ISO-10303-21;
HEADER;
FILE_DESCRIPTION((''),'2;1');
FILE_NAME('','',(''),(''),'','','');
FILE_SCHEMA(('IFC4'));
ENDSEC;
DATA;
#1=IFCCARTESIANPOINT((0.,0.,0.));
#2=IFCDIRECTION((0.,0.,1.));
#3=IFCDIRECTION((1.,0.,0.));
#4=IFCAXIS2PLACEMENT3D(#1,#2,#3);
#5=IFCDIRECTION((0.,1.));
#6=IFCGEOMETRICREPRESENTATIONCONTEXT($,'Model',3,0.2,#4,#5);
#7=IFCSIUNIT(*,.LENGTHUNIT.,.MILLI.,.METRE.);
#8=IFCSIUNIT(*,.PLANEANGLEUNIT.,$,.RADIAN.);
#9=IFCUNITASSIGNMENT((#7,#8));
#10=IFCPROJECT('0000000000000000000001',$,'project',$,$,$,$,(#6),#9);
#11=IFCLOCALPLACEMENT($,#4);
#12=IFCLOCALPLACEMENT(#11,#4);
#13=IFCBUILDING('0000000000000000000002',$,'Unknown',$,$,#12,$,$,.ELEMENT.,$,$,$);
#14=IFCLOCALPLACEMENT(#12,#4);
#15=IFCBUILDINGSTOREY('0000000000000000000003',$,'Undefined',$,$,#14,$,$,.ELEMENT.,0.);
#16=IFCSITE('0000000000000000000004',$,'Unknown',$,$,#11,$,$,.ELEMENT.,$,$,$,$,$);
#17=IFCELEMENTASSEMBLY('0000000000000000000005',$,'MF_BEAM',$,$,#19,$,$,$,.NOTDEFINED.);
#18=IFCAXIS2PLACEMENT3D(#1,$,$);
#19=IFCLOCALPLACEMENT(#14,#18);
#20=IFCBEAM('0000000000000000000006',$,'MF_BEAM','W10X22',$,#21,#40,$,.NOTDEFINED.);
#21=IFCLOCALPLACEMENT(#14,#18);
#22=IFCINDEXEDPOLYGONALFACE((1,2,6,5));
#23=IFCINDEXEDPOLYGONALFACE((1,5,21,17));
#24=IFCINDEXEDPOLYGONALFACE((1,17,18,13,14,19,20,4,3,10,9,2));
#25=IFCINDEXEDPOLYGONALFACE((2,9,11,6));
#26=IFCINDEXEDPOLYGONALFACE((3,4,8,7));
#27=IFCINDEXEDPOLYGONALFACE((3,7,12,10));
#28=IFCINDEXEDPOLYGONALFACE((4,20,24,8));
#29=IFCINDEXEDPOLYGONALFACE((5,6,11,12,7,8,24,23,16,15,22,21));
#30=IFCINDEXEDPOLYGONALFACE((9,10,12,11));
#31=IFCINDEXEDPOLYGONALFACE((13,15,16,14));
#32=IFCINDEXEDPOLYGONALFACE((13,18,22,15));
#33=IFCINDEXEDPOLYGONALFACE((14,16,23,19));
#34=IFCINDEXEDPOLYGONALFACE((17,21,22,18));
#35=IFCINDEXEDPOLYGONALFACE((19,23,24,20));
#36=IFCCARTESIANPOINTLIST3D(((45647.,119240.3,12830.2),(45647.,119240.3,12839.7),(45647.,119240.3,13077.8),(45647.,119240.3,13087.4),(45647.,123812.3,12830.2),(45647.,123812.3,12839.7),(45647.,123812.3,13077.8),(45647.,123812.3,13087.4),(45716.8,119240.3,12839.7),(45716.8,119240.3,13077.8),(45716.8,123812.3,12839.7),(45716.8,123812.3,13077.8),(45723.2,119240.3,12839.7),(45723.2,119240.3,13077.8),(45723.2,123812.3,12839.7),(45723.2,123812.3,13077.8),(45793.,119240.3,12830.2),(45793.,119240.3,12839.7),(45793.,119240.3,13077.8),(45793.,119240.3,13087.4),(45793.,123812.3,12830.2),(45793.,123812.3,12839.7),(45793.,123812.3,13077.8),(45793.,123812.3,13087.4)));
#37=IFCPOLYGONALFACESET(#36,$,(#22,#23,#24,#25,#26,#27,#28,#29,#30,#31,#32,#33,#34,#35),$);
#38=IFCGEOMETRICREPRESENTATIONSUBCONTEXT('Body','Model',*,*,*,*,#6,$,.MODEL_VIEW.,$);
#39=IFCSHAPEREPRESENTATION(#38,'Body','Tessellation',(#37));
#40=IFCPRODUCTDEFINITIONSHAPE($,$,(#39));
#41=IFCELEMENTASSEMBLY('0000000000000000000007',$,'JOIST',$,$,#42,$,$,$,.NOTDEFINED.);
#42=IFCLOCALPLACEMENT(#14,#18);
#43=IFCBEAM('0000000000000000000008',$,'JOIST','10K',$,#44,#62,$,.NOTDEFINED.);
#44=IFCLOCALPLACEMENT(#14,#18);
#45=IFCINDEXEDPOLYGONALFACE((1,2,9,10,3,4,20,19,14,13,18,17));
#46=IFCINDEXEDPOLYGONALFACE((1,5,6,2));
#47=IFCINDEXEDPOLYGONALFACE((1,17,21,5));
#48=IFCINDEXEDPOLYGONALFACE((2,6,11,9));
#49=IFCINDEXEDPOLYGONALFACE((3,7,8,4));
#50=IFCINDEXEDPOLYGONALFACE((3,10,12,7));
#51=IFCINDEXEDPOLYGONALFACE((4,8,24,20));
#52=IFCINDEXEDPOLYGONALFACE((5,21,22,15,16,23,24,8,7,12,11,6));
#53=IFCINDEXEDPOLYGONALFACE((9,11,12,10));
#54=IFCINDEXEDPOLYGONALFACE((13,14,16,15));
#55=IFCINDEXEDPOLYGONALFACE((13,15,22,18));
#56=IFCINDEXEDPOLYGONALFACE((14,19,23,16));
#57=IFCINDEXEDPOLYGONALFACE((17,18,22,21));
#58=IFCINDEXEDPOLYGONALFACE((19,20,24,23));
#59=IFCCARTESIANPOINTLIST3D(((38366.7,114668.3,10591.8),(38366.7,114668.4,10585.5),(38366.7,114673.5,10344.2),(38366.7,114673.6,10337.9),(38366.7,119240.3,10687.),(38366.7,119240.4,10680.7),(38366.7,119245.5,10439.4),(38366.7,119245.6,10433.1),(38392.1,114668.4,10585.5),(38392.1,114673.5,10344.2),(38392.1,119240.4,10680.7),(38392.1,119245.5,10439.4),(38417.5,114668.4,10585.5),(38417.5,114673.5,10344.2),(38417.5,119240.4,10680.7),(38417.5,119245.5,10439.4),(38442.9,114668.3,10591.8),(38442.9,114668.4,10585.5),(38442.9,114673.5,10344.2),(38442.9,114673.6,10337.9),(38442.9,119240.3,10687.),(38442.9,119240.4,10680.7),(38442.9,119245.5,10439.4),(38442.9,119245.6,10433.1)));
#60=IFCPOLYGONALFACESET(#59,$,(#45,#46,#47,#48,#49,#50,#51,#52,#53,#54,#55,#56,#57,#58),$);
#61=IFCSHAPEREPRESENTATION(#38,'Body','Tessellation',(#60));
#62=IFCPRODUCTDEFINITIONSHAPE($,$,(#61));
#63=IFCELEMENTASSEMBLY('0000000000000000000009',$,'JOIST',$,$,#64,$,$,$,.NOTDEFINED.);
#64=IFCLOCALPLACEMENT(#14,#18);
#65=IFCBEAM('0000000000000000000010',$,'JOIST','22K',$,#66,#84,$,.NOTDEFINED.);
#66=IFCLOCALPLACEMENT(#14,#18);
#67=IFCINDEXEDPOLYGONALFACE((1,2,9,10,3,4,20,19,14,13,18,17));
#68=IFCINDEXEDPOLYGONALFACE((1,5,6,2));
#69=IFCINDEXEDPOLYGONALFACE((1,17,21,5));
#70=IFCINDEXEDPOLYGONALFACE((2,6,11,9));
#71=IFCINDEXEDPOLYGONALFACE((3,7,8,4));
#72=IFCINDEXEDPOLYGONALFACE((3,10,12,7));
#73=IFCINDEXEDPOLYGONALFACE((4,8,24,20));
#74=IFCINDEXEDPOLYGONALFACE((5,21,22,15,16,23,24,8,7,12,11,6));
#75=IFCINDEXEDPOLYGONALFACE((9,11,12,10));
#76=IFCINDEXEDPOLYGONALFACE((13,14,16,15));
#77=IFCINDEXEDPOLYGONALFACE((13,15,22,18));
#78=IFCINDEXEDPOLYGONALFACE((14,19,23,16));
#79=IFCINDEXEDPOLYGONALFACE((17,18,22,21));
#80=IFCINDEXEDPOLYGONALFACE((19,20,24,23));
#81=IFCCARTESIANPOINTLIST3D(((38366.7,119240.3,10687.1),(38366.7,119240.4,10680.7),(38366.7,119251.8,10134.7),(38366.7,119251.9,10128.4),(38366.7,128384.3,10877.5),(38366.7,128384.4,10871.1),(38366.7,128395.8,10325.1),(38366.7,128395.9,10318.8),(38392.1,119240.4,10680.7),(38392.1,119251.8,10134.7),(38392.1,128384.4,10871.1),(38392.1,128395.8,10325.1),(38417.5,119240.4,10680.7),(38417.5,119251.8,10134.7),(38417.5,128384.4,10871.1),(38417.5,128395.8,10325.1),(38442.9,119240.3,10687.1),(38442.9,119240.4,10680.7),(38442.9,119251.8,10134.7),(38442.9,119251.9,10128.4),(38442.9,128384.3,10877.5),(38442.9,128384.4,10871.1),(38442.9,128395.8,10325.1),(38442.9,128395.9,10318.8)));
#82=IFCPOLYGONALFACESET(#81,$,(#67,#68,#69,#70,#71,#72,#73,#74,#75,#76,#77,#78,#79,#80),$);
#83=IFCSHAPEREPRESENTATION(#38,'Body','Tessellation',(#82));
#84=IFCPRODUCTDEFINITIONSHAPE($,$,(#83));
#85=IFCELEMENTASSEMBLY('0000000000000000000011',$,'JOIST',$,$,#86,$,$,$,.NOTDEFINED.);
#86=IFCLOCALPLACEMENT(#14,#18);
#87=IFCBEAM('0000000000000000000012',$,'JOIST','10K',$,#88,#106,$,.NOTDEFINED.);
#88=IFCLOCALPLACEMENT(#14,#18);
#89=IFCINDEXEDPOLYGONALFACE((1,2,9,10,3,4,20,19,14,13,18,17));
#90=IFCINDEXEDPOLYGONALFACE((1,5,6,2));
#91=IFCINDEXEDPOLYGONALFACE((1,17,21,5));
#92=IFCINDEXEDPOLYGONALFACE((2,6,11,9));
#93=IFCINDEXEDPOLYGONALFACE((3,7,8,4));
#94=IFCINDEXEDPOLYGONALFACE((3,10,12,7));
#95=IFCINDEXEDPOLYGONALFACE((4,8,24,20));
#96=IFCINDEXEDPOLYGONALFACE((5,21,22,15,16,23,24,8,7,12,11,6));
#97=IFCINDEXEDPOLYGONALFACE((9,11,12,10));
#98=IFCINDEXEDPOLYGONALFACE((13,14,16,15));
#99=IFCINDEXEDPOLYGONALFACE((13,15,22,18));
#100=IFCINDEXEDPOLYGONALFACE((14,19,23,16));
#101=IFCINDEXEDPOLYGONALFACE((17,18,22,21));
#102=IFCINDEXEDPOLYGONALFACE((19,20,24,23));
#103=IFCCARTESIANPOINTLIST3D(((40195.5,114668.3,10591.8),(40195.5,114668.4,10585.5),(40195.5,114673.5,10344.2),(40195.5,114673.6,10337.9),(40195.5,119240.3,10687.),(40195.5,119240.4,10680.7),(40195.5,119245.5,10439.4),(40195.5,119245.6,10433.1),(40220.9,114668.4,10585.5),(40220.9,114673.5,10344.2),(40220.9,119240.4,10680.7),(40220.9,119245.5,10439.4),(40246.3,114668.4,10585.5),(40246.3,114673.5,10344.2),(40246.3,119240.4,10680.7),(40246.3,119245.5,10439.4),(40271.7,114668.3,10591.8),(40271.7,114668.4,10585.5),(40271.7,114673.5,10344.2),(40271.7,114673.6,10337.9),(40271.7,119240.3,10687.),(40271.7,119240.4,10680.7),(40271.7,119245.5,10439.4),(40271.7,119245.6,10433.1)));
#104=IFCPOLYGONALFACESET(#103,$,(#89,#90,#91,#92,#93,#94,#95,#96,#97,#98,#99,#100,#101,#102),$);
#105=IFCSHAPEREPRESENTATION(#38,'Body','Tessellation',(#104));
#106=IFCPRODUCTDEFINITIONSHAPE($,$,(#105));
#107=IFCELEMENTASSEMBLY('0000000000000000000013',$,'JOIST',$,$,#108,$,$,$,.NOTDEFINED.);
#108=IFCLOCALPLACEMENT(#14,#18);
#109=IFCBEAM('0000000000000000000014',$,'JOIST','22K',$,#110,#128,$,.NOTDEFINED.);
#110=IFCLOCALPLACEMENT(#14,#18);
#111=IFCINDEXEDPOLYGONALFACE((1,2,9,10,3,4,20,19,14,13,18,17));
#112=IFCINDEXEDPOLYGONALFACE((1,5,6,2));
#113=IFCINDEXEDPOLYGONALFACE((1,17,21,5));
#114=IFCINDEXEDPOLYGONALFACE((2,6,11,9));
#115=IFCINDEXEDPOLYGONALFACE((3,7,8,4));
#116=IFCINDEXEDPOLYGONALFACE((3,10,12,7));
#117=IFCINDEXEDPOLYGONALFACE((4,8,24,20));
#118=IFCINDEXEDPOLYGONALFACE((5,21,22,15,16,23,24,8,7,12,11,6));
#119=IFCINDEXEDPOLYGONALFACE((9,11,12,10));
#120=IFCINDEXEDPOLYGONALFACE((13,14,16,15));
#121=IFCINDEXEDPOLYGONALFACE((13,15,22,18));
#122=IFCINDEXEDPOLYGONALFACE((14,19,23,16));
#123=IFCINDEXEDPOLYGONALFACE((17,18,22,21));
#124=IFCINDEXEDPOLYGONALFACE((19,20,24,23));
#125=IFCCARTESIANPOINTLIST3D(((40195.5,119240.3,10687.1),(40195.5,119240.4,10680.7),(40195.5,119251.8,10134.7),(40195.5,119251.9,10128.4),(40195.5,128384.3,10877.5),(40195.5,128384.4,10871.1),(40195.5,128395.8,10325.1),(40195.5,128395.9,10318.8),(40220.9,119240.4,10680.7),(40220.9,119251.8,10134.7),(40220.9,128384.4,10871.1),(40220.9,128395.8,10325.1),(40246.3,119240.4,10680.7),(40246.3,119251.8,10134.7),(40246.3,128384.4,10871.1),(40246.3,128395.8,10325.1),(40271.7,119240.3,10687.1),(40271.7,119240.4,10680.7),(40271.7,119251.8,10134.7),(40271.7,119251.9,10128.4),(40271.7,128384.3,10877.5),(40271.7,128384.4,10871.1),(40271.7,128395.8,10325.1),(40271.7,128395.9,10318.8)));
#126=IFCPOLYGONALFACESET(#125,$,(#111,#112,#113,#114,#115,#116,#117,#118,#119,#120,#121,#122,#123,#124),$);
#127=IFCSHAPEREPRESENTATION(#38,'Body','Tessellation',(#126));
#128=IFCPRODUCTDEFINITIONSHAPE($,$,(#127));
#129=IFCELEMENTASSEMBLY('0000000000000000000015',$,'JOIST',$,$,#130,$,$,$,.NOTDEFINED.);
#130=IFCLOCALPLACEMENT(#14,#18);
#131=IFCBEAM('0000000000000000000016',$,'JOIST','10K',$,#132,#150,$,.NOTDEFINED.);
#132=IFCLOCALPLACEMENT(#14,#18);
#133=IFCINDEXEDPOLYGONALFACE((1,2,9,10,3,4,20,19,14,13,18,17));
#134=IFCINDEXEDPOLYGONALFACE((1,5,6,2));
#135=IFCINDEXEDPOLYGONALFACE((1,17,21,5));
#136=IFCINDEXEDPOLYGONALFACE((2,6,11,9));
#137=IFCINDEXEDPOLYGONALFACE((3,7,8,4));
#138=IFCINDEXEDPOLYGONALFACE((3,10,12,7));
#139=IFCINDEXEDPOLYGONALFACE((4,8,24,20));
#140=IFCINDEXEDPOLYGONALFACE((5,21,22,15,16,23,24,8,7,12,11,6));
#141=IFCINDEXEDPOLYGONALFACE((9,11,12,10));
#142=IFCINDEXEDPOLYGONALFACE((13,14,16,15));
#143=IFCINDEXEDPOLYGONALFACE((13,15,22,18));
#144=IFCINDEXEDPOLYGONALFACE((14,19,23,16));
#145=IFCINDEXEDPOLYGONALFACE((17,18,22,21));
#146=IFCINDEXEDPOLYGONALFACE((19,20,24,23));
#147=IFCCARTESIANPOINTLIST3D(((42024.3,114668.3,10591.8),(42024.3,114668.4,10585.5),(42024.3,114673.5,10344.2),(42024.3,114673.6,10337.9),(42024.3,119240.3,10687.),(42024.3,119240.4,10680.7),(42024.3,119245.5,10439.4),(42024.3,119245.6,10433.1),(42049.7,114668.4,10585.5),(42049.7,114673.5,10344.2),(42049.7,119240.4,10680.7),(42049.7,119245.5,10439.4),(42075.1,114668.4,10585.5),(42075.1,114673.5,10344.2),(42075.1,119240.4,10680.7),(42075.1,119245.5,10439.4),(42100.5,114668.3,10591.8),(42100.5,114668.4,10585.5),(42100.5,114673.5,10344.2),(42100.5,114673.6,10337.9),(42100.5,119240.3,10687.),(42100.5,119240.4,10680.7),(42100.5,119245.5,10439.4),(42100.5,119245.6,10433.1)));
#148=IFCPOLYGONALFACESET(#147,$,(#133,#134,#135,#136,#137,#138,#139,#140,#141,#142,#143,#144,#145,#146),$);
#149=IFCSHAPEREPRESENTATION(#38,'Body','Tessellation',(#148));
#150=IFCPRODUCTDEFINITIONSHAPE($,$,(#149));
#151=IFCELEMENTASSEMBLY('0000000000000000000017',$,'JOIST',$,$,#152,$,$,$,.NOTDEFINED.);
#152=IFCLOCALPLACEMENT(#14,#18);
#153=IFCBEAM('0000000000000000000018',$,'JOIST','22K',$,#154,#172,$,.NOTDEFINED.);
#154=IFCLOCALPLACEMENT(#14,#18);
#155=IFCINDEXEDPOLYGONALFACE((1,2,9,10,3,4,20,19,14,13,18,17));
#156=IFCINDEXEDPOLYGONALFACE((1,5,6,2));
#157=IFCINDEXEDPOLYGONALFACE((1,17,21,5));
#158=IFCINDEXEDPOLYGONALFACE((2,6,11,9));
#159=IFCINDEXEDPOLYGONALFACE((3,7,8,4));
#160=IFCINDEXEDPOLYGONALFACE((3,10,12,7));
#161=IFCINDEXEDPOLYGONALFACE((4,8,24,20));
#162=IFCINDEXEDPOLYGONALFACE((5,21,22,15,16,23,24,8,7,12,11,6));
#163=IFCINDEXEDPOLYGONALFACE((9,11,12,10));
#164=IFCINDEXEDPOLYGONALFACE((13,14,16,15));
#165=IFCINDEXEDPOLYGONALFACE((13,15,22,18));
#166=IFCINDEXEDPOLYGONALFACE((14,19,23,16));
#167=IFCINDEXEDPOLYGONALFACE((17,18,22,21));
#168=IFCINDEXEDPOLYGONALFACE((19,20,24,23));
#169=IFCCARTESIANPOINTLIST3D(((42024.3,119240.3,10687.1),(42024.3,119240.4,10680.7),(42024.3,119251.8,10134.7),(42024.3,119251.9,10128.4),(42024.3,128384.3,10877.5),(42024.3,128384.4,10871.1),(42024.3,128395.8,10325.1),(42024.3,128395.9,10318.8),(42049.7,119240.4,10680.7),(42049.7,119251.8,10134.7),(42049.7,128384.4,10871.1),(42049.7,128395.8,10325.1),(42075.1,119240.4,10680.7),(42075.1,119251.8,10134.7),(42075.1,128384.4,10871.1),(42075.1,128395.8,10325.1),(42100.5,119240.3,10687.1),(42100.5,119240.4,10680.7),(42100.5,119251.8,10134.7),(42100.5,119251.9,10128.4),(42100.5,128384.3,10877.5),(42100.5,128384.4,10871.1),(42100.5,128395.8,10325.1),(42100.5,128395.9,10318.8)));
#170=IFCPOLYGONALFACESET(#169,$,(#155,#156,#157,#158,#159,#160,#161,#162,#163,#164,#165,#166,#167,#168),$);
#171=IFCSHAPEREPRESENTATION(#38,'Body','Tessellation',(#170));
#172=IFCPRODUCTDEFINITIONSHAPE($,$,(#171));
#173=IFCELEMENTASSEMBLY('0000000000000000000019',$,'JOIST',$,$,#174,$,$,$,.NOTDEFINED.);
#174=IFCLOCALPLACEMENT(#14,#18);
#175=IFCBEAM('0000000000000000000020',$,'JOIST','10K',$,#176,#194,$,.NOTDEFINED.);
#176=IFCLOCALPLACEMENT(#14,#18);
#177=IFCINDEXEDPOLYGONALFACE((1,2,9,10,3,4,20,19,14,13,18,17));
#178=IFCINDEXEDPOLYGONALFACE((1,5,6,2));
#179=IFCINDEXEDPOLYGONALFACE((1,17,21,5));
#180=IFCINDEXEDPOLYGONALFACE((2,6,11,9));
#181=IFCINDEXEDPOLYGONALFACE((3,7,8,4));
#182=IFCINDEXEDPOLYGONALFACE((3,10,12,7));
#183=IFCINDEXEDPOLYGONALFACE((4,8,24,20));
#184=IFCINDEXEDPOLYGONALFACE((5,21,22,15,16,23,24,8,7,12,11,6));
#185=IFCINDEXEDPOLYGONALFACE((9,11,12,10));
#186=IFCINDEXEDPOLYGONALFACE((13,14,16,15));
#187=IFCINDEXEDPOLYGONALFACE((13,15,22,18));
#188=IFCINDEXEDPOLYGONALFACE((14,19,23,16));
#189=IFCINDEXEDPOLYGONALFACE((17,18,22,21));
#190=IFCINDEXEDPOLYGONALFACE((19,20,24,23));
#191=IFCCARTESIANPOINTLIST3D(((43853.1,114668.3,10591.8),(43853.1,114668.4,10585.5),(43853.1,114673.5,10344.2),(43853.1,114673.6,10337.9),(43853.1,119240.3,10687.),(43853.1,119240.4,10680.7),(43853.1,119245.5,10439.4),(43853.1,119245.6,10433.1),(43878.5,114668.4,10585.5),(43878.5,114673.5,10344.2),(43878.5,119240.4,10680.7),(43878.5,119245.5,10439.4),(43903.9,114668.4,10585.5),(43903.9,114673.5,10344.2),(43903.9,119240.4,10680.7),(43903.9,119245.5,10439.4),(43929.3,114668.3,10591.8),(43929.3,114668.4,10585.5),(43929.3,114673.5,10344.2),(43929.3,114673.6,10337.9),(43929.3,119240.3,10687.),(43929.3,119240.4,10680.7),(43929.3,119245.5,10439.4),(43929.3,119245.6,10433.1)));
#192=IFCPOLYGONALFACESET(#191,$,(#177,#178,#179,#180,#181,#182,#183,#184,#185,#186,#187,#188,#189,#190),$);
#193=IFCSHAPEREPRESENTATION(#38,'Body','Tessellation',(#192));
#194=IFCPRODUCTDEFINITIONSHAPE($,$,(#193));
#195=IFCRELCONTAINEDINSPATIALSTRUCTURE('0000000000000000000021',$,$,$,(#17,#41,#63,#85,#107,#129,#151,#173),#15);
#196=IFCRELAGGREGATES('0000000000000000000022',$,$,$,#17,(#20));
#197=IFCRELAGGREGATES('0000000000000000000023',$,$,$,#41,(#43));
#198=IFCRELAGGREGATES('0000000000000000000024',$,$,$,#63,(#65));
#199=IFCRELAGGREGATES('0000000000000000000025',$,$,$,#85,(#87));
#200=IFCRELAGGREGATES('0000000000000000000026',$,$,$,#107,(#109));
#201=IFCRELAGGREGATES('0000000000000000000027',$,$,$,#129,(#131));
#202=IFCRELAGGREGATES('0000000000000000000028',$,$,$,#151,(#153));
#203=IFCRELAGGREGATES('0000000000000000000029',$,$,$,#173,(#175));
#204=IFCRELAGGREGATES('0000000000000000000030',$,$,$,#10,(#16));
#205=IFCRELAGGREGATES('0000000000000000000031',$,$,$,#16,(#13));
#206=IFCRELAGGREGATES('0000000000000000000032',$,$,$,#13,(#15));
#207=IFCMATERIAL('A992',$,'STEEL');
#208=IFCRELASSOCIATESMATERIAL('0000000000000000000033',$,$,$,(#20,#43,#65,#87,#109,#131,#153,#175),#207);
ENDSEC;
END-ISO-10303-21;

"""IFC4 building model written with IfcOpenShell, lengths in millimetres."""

from ifc_helpers import new_model, si_unit, direction, frame, origin_with_axes, place, context, subcontext, project, spatial, line, indexed_curve, outline, extrude, material, element, aggregate, save


model = new_model("IFC4")

# Units and contexts
model_context = context("Model", 3, precision=0.2, world=origin_with_axes(), true_north=direction((0.0, 1.0)))
body_context = subcontext(model_context, "Body", "Model", "MODEL_VIEW")
ifc_project = project(units=[si_unit("LENGTHUNIT", "METRE", prefix="MILLI"), si_unit("PLANEANGLEUNIT", "RADIAN")], contexts=[model_context])

# Site, building, storey
site_placement = place(None, origin_with_axes())
site = spatial("IfcSite", under=ifc_project, at=site_placement, Name="Unknown", CompositionType="ELEMENT")
building_placement = place(site_placement, origin_with_axes())
building = spatial("IfcBuilding", under=site, at=building_placement, Name="Unknown", CompositionType="ELEMENT")
storey_placement = place(building_placement, origin_with_axes())
storey = spatial("IfcBuildingStorey", under=building, at=storey_placement, Name="Undefined", CompositionType="ELEMENT", Elevation=0.0)

# Element assemblies, beams
assembly_1_placement = place(storey_placement, frame((45720.0, 119240.3, 12958.8), z_axis=(1.0, 0.0, 0.0), x_axis=(0.0, 1.0, 0.0)))
assembly_1 = element("IfcElementAssembly", 1, at=assembly_1_placement, inside=storey, Name="MF_BEAM", PredefinedType="NOTDEFINED")
ifc_material_1 = material(Name="A992", Category="STEEL")
beam_1_placement = place(assembly_1_placement, origin_with_axes())
beam_1 = element("IfcBeam", 2, at=beam_1_placement, material=ifc_material_1, Name="MF_BEAM", Description="W10X22", PredefinedType="NOTDEFINED", context=body_context, shape_type="SolidModel", body=[
    extrude(outline(indexed_curve([(-73.0, -128.6), (73.0, -128.6), (73.0, -119.1), (3.2, -119.1), (3.2, 119.1), (73.0, 119.1), (73.0, 128.6), (-73.0, 128.6), (-73.0, 119.1), (-3.2, 119.1), (-3.2, -119.1), (-73.0, -119.1)], segments=[line(1, 2, 3, 4, 5, 6, 7, 8, 9, 10, 11, 12, 1)])), frame((0.0, 0.0, 0.0), z_axis=(-1.0, 0.0, 0.0), x_axis=(0.0, 0.0, 1.0)), (0.0, 0.0, -1.0), 4572.0),
])
aggregate(assembly_1, [beam_1])
assembly_2_placement = place(storey_placement, frame((38404.8, 114670.9, 10464.8), z_axis=(1.0, 0.0, 0.0), x_axis=(0.0, 0.999783, 0.020819)))
assembly_2 = element("IfcElementAssembly", 3, at=assembly_2_placement, inside=storey, Name="JOIST", PredefinedType="NOTDEFINED")
beam_2_placement = place(assembly_2_placement, origin_with_axes())
beam_2 = element("IfcBeam", 4, at=beam_2_placement, material=ifc_material_1, Name="JOIST", Description="10K", PredefinedType="NOTDEFINED", context=body_context, shape_type="SolidModel", body=[
    extrude(outline(indexed_curve([(-38.1, -127.0), (38.1, -127.0), (38.1, -120.7), (12.7, -120.7), (12.7, 120.7), (38.1, 120.7), (38.1, 127.0), (-38.1, 127.0), (-38.1, 120.7), (-12.7, 120.7), (-12.7, -120.7), (-38.1, -120.7)], segments=[line(1, 2, 3, 4, 5, 6, 7, 8, 9, 10, 11, 12, 1)])), frame((0.0, 0.0, 0.0), z_axis=(-1.0, 0.0, 0.0), x_axis=(0.0, 0.0, 1.0)), (0.0, 0.0, -1.0), 4573.0),
])
aggregate(assembly_2, [beam_2])
assembly_3_placement = place(storey_placement, frame((38404.8, 119246.1, 10407.7), z_axis=(1.0, 0.0, 0.0), x_axis=(0.0, 0.999783, 0.020819)))
assembly_3 = element("IfcElementAssembly", 5, at=assembly_3_placement, inside=storey, Name="JOIST", PredefinedType="NOTDEFINED")
beam_3_placement = place(assembly_3_placement, origin_with_axes())
beam_3 = element("IfcBeam", 6, at=beam_3_placement, material=ifc_material_1, Name="JOIST", Description="22K", PredefinedType="NOTDEFINED", context=body_context, shape_type="SolidModel", body=[
    extrude(outline(indexed_curve([(-38.1, -279.4), (38.1, -279.4), (38.1, -273.0), (12.7, -273.0), (12.7, 273.0), (38.1, 273.0), (38.1, 279.4), (-38.1, 279.4), (-38.1, 273.0), (-12.7, 273.0), (-12.7, -273.0), (-38.1, -273.0)], segments=[line(1, 2, 3, 4, 5, 6, 7, 8, 9, 10, 11, 12, 1)])), frame((0.0, 0.0, 0.0), z_axis=(-1.0, 0.0, 0.0), x_axis=(0.0, 0.0, 1.0)), (0.0, 0.0, -1.0), 9146.0),
])
aggregate(assembly_3, [beam_3])
assembly_4_placement = place(storey_placement, frame((40233.6, 114670.9, 10464.8), z_axis=(1.0, 0.0, 0.0), x_axis=(0.0, 0.999783, 0.020819)))
assembly_4 = element("IfcElementAssembly", 7, at=assembly_4_placement, inside=storey, Name="JOIST", PredefinedType="NOTDEFINED")
beam_4_placement = place(assembly_4_placement, origin_with_axes())
beam_4 = element("IfcBeam", 8, at=beam_4_placement, material=ifc_material_1, Name="JOIST", Description="10K", PredefinedType="NOTDEFINED", context=body_context, shape_type="SolidModel", body=[
    extrude(outline(indexed_curve([(-38.1, -127.0), (38.1, -127.0), (38.1, -120.7), (12.7, -120.7), (12.7, 120.7), (38.1, 120.7), (38.1, 127.0), (-38.1, 127.0), (-38.1, 120.7), (-12.7, 120.7), (-12.7, -120.7), (-38.1, -120.7)], segments=[line(1, 2, 3, 4, 5, 6, 7, 8, 9, 10, 11, 12, 1)])), frame((0.0, 0.0, 0.0), z_axis=(-1.0, 0.0, 0.0), x_axis=(0.0, 0.0, 1.0)), (0.0, 0.0, -1.0), 4573.0),
])
aggregate(assembly_4, [beam_4])
assembly_5_placement = place(storey_placement, frame((40233.6, 119246.1, 10407.7), z_axis=(1.0, 0.0, 0.0), x_axis=(0.0, 0.999783, 0.020819)))
assembly_5 = element("IfcElementAssembly", 9, at=assembly_5_placement, inside=storey, Name="JOIST", PredefinedType="NOTDEFINED")
beam_5_placement = place(assembly_5_placement, origin_with_axes())
beam_5 = element("IfcBeam", 10, at=beam_5_placement, material=ifc_material_1, Name="JOIST", Description="22K", PredefinedType="NOTDEFINED", context=body_context, shape_type="SolidModel", body=[
    extrude(outline(indexed_curve([(-38.1, -279.4), (38.1, -279.4), (38.1, -273.0), (12.7, -273.0), (12.7, 273.0), (38.1, 273.0), (38.1, 279.4), (-38.1, 279.4), (-38.1, 273.0), (-12.7, 273.0), (-12.7, -273.0), (-38.1, -273.0)], segments=[line(1, 2, 3, 4, 5, 6, 7, 8, 9, 10, 11, 12, 1)])), frame((0.0, 0.0, 0.0), z_axis=(-1.0, 0.0, 0.0), x_axis=(0.0, 0.0, 1.0)), (0.0, 0.0, -1.0), 9146.0),
])
aggregate(assembly_5, [beam_5])
assembly_6_placement = place(storey_placement, frame((42062.4, 114670.9, 10464.8), z_axis=(1.0, 0.0, 0.0), x_axis=(0.0, 0.999783, 0.020819)))
assembly_6 = element("IfcElementAssembly", 11, at=assembly_6_placement, inside=storey, Name="JOIST", PredefinedType="NOTDEFINED")
beam_6_placement = place(assembly_6_placement, origin_with_axes())
beam_6 = element("IfcBeam", 12, at=beam_6_placement, material=ifc_material_1, Name="JOIST", Description="10K", PredefinedType="NOTDEFINED", context=body_context, shape_type="SolidModel", body=[
    extrude(outline(indexed_curve([(-38.1, -127.0), (38.1, -127.0), (38.1, -120.7), (12.7, -120.7), (12.7, 120.7), (38.1, 120.7), (38.1, 127.0), (-38.1, 127.0), (-38.1, 120.7), (-12.7, 120.7), (-12.7, -120.7), (-38.1, -120.7)], segments=[line(1, 2, 3, 4, 5, 6, 7, 8, 9, 10, 11, 12, 1)])), frame((0.0, 0.0, 0.0), z_axis=(-1.0, 0.0, 0.0), x_axis=(0.0, 0.0, 1.0)), (0.0, 0.0, -1.0), 4573.0),
])
aggregate(assembly_6, [beam_6])
assembly_7_placement = place(storey_placement, frame((42062.4, 119246.1, 10407.7), z_axis=(1.0, 0.0, 0.0), x_axis=(0.0, 0.999783, 0.020819)))
assembly_7 = element("IfcElementAssembly", 13, at=assembly_7_placement, inside=storey, Name="JOIST", PredefinedType="NOTDEFINED")
beam_7_placement = place(assembly_7_placement, origin_with_axes())
beam_7 = element("IfcBeam", 14, at=beam_7_placement, material=ifc_material_1, Name="JOIST", Description="22K", PredefinedType="NOTDEFINED", context=body_context, shape_type="SolidModel", body=[
    extrude(outline(indexed_curve([(-38.1, -279.4), (38.1, -279.4), (38.1, -273.0), (12.7, -273.0), (12.7, 273.0), (38.1, 273.0), (38.1, 279.4), (-38.1, 279.4), (-38.1, 273.0), (-12.7, 273.0), (-12.7, -273.0), (-38.1, -273.0)], segments=[line(1, 2, 3, 4, 5, 6, 7, 8, 9, 10, 11, 12, 1)])), frame((0.0, 0.0, 0.0), z_axis=(-1.0, 0.0, 0.0), x_axis=(0.0, 0.0, 1.0)), (0.0, 0.0, -1.0), 9146.0),
])
aggregate(assembly_7, [beam_7])
assembly_8_placement = place(storey_placement, frame((43891.2, 114670.9, 10464.8), z_axis=(1.0, 0.0, 0.0), x_axis=(0.0, 0.999783, 0.020819)))
assembly_8 = element("IfcElementAssembly", 15, at=assembly_8_placement, inside=storey, Name="JOIST", PredefinedType="NOTDEFINED")
beam_8_placement = place(assembly_8_placement, origin_with_axes())
beam_8 = element("IfcBeam", 16, at=beam_8_placement, material=ifc_material_1, Name="JOIST", Description="10K", PredefinedType="NOTDEFINED", context=body_context, shape_type="SolidModel", body=[
    extrude(outline(indexed_curve([(-38.1, -127.0), (38.1, -127.0), (38.1, -120.7), (12.7, -120.7), (12.7, 120.7), (38.1, 120.7), (38.1, 127.0), (-38.1, 127.0), (-38.1, 120.7), (-12.7, 120.7), (-12.7, -120.7), (-38.1, -120.7)], segments=[line(1, 2, 3, 4, 5, 6, 7, 8, 9, 10, 11, 12, 1)])), frame((0.0, 0.0, 0.0), z_axis=(-1.0, 0.0, 0.0), x_axis=(0.0, 0.0, 1.0)), (0.0, 0.0, -1.0), 4573.0),
])
aggregate(assembly_8, [beam_8])

save(model, "model.ifc")
